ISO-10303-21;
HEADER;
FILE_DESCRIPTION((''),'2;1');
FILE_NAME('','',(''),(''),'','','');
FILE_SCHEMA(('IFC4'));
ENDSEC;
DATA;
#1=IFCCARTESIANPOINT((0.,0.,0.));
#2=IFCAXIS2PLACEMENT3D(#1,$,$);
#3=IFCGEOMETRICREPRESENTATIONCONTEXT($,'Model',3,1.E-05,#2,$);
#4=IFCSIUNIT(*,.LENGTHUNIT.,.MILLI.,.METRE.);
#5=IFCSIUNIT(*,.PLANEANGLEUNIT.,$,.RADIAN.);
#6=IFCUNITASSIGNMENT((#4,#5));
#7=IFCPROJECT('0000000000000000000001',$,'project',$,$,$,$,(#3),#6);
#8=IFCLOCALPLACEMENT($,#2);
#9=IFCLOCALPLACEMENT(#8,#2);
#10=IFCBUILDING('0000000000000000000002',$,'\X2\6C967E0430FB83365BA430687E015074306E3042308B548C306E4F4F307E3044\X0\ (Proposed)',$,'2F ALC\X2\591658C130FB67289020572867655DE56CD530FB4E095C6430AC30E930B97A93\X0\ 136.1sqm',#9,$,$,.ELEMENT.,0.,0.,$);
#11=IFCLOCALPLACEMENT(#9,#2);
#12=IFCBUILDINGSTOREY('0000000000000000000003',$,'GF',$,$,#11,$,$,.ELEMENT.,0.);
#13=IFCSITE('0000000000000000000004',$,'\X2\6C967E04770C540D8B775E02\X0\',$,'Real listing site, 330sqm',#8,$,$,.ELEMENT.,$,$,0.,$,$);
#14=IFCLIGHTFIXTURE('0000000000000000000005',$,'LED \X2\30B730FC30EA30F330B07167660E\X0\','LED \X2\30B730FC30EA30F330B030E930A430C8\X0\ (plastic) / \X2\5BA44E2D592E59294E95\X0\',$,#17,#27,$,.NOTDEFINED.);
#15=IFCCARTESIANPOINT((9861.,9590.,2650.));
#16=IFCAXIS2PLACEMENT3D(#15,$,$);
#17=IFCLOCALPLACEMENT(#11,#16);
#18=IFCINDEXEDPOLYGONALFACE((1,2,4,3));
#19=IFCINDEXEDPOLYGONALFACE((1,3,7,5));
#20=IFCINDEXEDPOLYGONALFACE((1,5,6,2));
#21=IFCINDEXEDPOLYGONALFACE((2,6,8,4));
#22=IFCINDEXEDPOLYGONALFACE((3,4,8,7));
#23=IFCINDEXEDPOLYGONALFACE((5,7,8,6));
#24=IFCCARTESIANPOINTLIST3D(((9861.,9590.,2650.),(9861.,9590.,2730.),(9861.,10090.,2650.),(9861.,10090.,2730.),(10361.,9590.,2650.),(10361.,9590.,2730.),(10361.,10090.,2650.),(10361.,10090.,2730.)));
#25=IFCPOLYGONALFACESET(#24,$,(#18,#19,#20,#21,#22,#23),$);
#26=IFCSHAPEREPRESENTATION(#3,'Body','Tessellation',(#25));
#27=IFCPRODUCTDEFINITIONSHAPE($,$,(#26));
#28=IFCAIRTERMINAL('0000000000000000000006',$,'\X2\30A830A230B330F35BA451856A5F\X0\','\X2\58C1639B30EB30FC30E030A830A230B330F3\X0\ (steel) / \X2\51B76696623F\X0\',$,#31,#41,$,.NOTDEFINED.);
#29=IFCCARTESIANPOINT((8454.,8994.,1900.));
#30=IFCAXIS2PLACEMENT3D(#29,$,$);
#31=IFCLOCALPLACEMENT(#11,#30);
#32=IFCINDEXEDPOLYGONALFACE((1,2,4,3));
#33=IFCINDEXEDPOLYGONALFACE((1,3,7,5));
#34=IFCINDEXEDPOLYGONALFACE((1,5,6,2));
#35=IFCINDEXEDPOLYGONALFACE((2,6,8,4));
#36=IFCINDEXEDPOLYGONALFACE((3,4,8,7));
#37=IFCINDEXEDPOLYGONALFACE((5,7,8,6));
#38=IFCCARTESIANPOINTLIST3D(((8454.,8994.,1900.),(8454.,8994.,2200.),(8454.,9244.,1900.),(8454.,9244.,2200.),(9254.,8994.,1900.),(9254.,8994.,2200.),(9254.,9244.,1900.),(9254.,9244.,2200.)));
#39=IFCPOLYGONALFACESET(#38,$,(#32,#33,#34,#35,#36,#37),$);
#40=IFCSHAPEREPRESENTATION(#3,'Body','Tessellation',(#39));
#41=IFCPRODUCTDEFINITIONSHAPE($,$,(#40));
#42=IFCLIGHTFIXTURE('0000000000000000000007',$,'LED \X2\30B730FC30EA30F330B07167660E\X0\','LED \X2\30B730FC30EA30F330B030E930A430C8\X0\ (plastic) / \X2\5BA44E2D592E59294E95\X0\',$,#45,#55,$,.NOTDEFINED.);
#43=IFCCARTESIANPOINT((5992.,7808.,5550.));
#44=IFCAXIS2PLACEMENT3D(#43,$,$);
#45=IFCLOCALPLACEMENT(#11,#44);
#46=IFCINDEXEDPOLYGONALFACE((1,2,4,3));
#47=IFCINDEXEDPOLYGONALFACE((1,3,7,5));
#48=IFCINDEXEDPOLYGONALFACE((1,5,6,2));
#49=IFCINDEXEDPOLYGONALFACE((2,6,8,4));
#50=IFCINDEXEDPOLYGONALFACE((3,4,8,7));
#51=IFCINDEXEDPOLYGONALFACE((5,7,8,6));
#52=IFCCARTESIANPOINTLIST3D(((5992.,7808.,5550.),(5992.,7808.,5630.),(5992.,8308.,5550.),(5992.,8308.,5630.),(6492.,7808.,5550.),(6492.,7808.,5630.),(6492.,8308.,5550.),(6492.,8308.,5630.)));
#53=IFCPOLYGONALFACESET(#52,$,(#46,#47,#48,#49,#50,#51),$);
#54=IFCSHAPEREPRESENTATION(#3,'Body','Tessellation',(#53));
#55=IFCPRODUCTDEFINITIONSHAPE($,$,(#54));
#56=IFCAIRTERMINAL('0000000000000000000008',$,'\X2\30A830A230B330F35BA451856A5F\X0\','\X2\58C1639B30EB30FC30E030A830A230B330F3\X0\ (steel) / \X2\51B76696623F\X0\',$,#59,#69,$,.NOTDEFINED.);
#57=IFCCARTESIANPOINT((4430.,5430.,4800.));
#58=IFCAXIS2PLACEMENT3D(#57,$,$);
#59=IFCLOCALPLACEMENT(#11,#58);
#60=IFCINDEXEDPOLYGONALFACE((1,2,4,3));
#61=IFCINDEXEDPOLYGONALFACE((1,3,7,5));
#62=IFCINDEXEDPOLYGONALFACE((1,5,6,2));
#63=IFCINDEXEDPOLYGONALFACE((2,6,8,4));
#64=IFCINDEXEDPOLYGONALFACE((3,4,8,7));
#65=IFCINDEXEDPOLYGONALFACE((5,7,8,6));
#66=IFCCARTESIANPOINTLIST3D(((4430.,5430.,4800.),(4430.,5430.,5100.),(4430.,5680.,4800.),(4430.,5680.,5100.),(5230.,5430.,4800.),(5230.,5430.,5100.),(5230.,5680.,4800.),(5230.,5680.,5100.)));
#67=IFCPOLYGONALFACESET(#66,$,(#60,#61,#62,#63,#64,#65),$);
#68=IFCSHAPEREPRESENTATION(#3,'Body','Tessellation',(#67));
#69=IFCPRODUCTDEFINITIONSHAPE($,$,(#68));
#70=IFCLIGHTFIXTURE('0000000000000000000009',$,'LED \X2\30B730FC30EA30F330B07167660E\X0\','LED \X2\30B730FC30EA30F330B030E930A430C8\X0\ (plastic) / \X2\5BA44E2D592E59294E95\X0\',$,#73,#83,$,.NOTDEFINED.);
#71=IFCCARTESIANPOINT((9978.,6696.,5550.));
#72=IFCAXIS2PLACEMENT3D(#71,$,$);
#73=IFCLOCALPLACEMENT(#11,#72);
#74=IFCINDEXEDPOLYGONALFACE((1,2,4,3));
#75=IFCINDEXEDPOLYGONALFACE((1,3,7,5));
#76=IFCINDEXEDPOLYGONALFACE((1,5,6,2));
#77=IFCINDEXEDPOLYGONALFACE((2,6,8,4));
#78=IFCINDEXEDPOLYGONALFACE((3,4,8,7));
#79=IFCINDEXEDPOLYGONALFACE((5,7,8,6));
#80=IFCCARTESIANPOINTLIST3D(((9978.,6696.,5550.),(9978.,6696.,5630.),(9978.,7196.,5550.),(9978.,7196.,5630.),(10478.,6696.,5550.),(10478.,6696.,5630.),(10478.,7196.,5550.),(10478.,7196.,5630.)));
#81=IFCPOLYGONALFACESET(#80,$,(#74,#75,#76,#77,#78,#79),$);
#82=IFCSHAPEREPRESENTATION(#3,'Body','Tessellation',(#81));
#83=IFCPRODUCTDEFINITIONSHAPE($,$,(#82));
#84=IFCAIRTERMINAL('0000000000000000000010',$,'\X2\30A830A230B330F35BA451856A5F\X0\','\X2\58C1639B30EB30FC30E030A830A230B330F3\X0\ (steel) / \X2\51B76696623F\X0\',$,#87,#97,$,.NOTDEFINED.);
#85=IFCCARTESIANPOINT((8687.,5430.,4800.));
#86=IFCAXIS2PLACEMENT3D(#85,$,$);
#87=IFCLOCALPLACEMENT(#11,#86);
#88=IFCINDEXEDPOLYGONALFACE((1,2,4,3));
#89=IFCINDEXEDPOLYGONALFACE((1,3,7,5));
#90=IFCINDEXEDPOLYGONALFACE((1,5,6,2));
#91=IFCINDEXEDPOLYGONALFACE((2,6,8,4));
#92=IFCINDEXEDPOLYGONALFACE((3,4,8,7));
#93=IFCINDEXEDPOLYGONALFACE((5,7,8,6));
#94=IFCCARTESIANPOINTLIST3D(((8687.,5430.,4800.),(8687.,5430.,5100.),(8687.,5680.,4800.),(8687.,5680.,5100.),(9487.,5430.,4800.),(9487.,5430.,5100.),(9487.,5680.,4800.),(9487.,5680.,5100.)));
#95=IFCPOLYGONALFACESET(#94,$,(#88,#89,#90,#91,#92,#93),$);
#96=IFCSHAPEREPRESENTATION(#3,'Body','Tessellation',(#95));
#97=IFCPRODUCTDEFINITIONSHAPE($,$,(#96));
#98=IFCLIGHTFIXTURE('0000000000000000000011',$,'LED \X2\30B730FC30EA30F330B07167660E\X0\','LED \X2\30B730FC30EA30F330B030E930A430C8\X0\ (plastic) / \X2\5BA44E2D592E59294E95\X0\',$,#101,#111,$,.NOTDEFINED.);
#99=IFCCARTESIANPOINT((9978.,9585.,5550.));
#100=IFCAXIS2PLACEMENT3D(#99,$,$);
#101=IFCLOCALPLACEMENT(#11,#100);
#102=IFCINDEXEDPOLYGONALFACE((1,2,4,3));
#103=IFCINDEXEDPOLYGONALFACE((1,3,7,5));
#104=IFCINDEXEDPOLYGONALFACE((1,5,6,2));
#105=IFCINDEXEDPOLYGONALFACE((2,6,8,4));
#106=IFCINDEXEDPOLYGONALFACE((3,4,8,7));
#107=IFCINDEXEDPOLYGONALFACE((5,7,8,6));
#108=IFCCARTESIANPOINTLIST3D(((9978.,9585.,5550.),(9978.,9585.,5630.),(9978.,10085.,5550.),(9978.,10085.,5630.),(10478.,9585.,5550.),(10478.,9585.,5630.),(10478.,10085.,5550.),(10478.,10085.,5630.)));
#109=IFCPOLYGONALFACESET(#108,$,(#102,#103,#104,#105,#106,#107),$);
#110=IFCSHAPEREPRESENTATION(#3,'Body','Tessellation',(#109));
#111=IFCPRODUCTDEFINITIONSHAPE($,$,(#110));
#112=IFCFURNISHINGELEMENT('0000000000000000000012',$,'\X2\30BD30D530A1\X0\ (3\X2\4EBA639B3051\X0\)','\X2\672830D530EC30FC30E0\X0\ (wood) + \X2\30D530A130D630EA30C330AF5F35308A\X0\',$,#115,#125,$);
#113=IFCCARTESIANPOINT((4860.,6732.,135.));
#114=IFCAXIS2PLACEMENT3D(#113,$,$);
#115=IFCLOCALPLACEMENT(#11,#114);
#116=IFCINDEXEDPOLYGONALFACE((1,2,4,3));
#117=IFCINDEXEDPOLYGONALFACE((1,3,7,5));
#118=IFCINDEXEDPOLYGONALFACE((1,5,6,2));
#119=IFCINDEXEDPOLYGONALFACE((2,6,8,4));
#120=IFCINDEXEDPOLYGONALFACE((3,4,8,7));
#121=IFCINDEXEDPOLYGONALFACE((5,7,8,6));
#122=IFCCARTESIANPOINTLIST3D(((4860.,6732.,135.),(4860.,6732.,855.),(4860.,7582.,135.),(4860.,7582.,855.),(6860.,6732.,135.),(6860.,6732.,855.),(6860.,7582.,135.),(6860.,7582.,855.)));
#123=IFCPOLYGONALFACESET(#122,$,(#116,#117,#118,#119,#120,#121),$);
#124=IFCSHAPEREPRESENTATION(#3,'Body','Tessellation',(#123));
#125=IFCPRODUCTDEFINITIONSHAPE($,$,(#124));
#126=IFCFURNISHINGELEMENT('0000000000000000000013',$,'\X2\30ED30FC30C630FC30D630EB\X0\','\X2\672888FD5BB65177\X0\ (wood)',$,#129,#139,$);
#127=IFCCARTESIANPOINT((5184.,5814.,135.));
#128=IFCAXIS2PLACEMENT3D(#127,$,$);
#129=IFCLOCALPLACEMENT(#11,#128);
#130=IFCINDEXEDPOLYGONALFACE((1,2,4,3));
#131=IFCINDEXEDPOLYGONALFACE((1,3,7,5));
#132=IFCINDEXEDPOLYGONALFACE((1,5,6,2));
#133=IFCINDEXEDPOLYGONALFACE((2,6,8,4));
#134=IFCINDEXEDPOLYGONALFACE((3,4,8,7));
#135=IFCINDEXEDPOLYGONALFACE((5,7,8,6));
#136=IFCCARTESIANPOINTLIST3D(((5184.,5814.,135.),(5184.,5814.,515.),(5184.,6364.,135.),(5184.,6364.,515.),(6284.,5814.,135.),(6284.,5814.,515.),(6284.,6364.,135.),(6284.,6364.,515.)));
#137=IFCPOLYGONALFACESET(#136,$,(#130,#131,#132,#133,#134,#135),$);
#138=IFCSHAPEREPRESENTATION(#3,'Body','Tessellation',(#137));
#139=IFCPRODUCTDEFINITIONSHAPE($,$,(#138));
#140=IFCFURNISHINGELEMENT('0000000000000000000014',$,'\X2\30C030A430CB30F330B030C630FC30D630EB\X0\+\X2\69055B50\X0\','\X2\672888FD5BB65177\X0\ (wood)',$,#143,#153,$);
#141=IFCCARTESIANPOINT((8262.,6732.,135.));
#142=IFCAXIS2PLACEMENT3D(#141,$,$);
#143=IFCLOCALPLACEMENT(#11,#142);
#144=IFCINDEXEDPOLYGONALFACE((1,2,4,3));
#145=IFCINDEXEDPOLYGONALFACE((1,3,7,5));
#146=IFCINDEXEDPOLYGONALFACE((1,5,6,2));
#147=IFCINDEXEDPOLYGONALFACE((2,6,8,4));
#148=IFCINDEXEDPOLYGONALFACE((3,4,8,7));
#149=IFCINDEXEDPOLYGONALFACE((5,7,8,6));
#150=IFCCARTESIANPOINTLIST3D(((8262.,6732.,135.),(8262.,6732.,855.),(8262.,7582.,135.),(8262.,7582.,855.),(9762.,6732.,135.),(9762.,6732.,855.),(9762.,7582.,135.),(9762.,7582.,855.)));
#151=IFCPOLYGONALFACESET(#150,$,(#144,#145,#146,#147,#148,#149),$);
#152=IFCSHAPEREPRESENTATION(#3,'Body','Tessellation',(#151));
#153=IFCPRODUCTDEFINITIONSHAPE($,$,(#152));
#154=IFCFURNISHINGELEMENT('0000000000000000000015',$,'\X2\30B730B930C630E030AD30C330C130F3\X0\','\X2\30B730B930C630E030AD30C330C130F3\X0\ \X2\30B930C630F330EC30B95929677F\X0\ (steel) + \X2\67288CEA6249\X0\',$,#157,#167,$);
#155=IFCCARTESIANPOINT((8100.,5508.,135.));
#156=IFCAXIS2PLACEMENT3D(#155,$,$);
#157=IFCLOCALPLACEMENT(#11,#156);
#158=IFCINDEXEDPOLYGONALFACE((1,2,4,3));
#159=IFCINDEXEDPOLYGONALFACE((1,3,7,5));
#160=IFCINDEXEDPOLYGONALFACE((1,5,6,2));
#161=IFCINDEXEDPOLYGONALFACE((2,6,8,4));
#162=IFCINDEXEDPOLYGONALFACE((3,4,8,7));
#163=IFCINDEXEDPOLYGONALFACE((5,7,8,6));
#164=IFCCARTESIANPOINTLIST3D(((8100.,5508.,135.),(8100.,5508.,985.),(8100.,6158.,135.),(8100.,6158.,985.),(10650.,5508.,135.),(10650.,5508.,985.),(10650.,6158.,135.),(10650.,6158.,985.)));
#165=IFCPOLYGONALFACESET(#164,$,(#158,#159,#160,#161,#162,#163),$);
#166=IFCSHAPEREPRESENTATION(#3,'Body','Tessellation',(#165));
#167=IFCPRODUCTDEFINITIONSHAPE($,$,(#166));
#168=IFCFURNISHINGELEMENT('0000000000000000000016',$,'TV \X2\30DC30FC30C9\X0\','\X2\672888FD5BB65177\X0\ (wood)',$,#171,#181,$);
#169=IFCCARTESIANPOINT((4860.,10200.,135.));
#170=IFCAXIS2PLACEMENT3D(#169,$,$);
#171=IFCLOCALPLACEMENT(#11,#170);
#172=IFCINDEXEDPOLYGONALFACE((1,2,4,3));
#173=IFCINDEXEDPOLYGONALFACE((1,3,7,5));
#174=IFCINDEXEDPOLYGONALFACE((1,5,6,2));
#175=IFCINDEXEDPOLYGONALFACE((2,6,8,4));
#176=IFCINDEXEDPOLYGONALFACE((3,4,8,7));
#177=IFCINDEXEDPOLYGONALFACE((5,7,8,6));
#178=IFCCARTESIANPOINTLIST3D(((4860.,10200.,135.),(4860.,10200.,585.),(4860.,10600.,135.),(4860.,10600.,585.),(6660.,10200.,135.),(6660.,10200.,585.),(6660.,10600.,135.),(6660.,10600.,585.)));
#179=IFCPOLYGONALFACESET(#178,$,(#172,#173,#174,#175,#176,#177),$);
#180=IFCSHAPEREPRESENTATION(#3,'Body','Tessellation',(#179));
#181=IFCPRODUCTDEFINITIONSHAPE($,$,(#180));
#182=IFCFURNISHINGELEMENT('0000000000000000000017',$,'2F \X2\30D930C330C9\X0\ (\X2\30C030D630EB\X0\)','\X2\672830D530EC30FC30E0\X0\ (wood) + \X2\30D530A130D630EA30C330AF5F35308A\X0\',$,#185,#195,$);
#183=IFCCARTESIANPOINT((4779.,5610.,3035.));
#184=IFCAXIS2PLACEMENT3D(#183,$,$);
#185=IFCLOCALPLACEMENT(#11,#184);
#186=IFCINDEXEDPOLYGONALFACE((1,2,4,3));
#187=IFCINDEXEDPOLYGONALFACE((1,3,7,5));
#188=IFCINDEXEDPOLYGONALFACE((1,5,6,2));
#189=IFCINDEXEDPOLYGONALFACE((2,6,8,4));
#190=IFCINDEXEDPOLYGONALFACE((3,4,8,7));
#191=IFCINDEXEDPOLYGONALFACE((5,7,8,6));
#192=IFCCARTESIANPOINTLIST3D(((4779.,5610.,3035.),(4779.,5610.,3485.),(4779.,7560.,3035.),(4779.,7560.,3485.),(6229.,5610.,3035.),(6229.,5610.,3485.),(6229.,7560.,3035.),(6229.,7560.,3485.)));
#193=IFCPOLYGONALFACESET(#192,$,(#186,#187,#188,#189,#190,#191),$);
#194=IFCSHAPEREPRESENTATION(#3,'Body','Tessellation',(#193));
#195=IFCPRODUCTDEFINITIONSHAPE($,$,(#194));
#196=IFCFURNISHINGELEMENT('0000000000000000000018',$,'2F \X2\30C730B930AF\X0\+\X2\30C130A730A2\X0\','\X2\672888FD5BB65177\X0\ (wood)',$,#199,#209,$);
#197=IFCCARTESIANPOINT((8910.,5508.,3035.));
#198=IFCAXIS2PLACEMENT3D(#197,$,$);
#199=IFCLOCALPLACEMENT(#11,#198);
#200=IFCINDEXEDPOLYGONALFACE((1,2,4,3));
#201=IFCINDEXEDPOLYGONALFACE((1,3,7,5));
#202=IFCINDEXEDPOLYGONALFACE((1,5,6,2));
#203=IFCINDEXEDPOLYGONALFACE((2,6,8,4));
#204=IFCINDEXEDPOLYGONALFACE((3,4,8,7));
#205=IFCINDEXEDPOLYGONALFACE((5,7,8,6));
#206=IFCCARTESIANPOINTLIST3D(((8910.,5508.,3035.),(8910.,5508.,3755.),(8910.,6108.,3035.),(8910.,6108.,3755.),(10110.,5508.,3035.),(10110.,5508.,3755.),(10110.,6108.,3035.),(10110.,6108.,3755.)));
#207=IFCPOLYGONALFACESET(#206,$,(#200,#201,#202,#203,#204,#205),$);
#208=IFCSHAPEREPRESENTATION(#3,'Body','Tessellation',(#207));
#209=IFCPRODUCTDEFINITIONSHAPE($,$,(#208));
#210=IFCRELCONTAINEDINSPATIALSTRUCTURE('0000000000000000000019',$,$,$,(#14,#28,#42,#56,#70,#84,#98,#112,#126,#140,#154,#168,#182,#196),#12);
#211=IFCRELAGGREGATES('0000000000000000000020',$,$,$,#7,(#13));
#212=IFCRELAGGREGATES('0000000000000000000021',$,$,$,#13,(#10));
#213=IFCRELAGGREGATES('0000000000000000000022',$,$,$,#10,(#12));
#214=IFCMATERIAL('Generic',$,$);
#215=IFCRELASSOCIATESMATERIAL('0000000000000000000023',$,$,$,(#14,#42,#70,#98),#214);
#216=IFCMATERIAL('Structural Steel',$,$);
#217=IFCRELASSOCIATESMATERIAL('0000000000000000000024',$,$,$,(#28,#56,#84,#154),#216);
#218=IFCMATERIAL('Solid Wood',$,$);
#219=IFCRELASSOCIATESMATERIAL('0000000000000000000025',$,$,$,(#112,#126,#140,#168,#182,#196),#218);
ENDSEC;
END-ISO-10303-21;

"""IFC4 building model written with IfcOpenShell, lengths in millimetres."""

from ifc_helpers import new_model, si_unit, frame, frame_2d, origin, place, context, project, spatial, rectangle, extrude, material, element, save


model = new_model("IFC4")

# Units and contexts
model_context = context("Model", 3, precision=1e-05, world=origin())
ifc_project = project(units=[si_unit("LENGTHUNIT", "METRE", prefix="MILLI"), si_unit("PLANEANGLEUNIT", "RADIAN")], contexts=[model_context])

# Site, building, storey
site_placement = place(None, origin())
site = spatial("IfcSite", under=ifc_project, at=site_placement, Name="沖縄県名護市", ObjectType="Real listing site, 330sqm", CompositionType="ELEMENT", RefElevation=0.0)
building_placement = place(site_placement, origin())
building = spatial("IfcBuilding", under=site, at=building_placement, Name="沖縄・茶室と縁側のある和の住まい (Proposed)", ObjectType="2F ALC外壁・木造在来工法・三層ガラス窓 136.1sqm", CompositionType="ELEMENT", ElevationOfRefHeight=0.0, ElevationOfTerrain=0.0)
storey_placement = place(building_placement, origin())
storey = spatial("IfcBuildingStorey", under=building, at=storey_placement, Name="GF", CompositionType="ELEMENT", Elevation=0.0)

# Shared definitions
ifc_material_1 = material(Name="Solid Wood")

# Shared definitions
ifc_material_2 = material(Name="Structural Steel")

# Shared definitions
ifc_material_3 = material(Name="Generic")

# Light fixture
light_fixture_1_placement = place(storey_placement, frame((9861.0, 9590.0, 2650.0)))
element("IfcLightFixture", 1, at=light_fixture_1_placement, inside=storey, material=ifc_material_3, Name="LED シーリング照明", Description="LED シーリングライト (plastic) / 室中央天井", PredefinedType="NOTDEFINED", context=model_context, shape_type="SweptSolid", body=[
    extrude(rectangle(XDim=500.0, YDim=500.0, at=frame_2d((250.0, 250.0))), frame((9861.0, 9590.0, 2650.0)), (0.0, 0.0, 1.0), 80.0),
])

# Air terminal
air_terminal_1_placement = place(storey_placement, frame((8454.0, 8994.0, 1900.0)))
element("IfcAirTerminal", 2, at=air_terminal_1_placement, inside=storey, material=ifc_material_2, Name="エアコン室内機", Description="壁掛ルームエアコン (steel) / 冷暖房", PredefinedType="NOTDEFINED", context=model_context, shape_type="SweptSolid", body=[
    extrude(rectangle(XDim=800.0, YDim=250.0, at=frame_2d((400.0, 125.0))), frame((8454.0, 8994.0, 1900.0)), (0.0, 0.0, 1.0), 300.0),
])

# Light fixture
light_fixture_2_placement = place(storey_placement, frame((5992.0, 7808.0, 5550.0)))
element("IfcLightFixture", 3, at=light_fixture_2_placement, inside=storey, material=ifc_material_3, Name="LED シーリング照明", Description="LED シーリングライト (plastic) / 室中央天井", PredefinedType="NOTDEFINED", context=model_context, shape_type="SweptSolid", body=[
    extrude(rectangle(XDim=500.0, YDim=500.0, at=frame_2d((250.0, 250.0))), frame((5992.0, 7808.0, 5550.0)), (0.0, 0.0, 1.0), 80.0),
])

# Air terminal
air_terminal_2_placement = place(storey_placement, frame((4430.0, 5430.0, 4800.0)))
element("IfcAirTerminal", 4, at=air_terminal_2_placement, inside=storey, material=ifc_material_2, Name="エアコン室内機", Description="壁掛ルームエアコン (steel) / 冷暖房", PredefinedType="NOTDEFINED", context=model_context, shape_type="SweptSolid", body=[
    extrude(rectangle(XDim=800.0, YDim=250.0, at=frame_2d((400.0, 125.0))), frame((4430.0, 5430.0, 4800.0)), (0.0, 0.0, 1.0), 300.0),
])

# Light fixture
light_fixture_3_placement = place(storey_placement, frame((9978.0, 6696.0, 5550.0)))
element("IfcLightFixture", 5, at=light_fixture_3_placement, inside=storey, material=ifc_material_3, Name="LED シーリング照明", Description="LED シーリングライト (plastic) / 室中央天井", PredefinedType="NOTDEFINED", context=model_context, shape_type="SweptSolid", body=[
    extrude(rectangle(XDim=500.0, YDim=500.0, at=frame_2d((250.0, 250.0))), frame((9978.0, 6696.0, 5550.0)), (0.0, 0.0, 1.0), 80.0),
])

# Air terminal
air_terminal_3_placement = place(storey_placement, frame((8687.0, 5430.0, 4800.0)))
element("IfcAirTerminal", 6, at=air_terminal_3_placement, inside=storey, material=ifc_material_2, Name="エアコン室内機", Description="壁掛ルームエアコン (steel) / 冷暖房", PredefinedType="NOTDEFINED", context=model_context, shape_type="SweptSolid", body=[
    extrude(rectangle(XDim=800.0, YDim=250.0, at=frame_2d((400.0, 125.0))), frame((8687.0, 5430.0, 4800.0)), (0.0, 0.0, 1.0), 300.0),
])

# Light fixture
light_fixture_4_placement = place(storey_placement, frame((9978.0, 9585.0, 5550.0)))
element("IfcLightFixture", 7, at=light_fixture_4_placement, inside=storey, material=ifc_material_3, Name="LED シーリング照明", Description="LED シーリングライト (plastic) / 室中央天井", PredefinedType="NOTDEFINED", context=model_context, shape_type="SweptSolid", body=[
    extrude(rectangle(XDim=500.0, YDim=500.0, at=frame_2d((250.0, 250.0))), frame((9978.0, 9585.0, 5550.0)), (0.0, 0.0, 1.0), 80.0),
])

# Furnishing elements
furnishing_1_placement = place(storey_placement, frame((4860.0, 6732.0, 135.0)))
element("IfcFurnishingElement", 8, at=furnishing_1_placement, inside=storey, material=ifc_material_1, Name="ソファ (3人掛け)", Description="木フレーム (wood) + ファブリック張り", context=model_context, shape_type="SweptSolid", body=[
    extrude(rectangle(XDim=2000.0, YDim=850.0, at=frame_2d((1000.0, 425.0))), frame((4860.0, 6732.0, 135.0)), (0.0, 0.0, 1.0), 720.0),
])
furnishing_2_placement = place(storey_placement, frame((5184.0, 5814.0, 135.0)))
element("IfcFurnishingElement", 9, at=furnishing_2_placement, inside=storey, material=ifc_material_1, Name="ローテーブル", Description="木製家具 (wood)", context=model_context, shape_type="SweptSolid", body=[
    extrude(rectangle(XDim=1100.0, YDim=550.0, at=frame_2d((550.0, 275.0))), frame((5184.0, 5814.0, 135.0)), (0.0, 0.0, 1.0), 380.0),
])
furnishing_3_placement = place(storey_placement, frame((8262.0, 6732.0, 135.0)))
element("IfcFurnishingElement", 10, at=furnishing_3_placement, inside=storey, material=ifc_material_1, Name="ダイニングテーブル+椅子", Description="木製家具 (wood)", context=model_context, shape_type="SweptSolid", body=[
    extrude(rectangle(XDim=1500.0, YDim=850.0, at=frame_2d((750.0, 425.0))), frame((8262.0, 6732.0, 135.0)), (0.0, 0.0, 1.0), 720.0),
])
furnishing_4_placement = place(storey_placement, frame((8100.0, 5508.0, 135.0)))
element("IfcFurnishingElement", 11, at=furnishing_4_placement, inside=storey, material=ifc_material_2, Name="システムキッチン", Description="システムキッチン ステンレス天板 (steel) + 木質扉", context=model_context, shape_type="SweptSolid", body=[
    extrude(rectangle(XDim=2550.0, YDim=650.0, at=frame_2d((1275.0, 325.0))), frame((8100.0, 5508.0, 135.0)), (0.0, 0.0, 1.0), 850.0),
])
furnishing_5_placement = place(storey_placement, frame((4860.0, 10200.0, 135.0)))
element("IfcFurnishingElement", 12, at=furnishing_5_placement, inside=storey, material=ifc_material_1, Name="TV ボード", Description="木製家具 (wood)", context=model_context, shape_type="SweptSolid", body=[
    extrude(rectangle(XDim=1800.0, YDim=400.0, at=frame_2d((900.0, 200.0))), frame((4860.0, 10200.0, 135.0)), (0.0, 0.0, 1.0), 450.0),
])
furnishing_6_placement = place(storey_placement, frame((4779.0, 5610.0, 3035.0)))
element("IfcFurnishingElement", 13, at=furnishing_6_placement, inside=storey, material=ifc_material_1, Name="2F ベッド (ダブル)", Description="木フレーム (wood) + ファブリック張り", context=model_context, shape_type="SweptSolid", body=[
    extrude(rectangle(XDim=1450.0, YDim=1950.0, at=frame_2d((725.0, 975.0))), frame((4779.0, 5610.0, 3035.0)), (0.0, 0.0, 1.0), 450.0),
])
furnishing_7_placement = place(storey_placement, frame((8910.0, 5508.0, 3035.0)))
element("IfcFurnishingElement", 14, at=furnishing_7_placement, inside=storey, material=ifc_material_1, Name="2F デスク+チェア", Description="木製家具 (wood)", context=model_context, shape_type="SweptSolid", body=[
    extrude(rectangle(XDim=1200.0, YDim=600.0, at=frame_2d((600.0, 300.0))), frame((8910.0, 5508.0, 3035.0)), (0.0, 0.0, 1.0), 720.0),
])

save(model, "model.ifc")
